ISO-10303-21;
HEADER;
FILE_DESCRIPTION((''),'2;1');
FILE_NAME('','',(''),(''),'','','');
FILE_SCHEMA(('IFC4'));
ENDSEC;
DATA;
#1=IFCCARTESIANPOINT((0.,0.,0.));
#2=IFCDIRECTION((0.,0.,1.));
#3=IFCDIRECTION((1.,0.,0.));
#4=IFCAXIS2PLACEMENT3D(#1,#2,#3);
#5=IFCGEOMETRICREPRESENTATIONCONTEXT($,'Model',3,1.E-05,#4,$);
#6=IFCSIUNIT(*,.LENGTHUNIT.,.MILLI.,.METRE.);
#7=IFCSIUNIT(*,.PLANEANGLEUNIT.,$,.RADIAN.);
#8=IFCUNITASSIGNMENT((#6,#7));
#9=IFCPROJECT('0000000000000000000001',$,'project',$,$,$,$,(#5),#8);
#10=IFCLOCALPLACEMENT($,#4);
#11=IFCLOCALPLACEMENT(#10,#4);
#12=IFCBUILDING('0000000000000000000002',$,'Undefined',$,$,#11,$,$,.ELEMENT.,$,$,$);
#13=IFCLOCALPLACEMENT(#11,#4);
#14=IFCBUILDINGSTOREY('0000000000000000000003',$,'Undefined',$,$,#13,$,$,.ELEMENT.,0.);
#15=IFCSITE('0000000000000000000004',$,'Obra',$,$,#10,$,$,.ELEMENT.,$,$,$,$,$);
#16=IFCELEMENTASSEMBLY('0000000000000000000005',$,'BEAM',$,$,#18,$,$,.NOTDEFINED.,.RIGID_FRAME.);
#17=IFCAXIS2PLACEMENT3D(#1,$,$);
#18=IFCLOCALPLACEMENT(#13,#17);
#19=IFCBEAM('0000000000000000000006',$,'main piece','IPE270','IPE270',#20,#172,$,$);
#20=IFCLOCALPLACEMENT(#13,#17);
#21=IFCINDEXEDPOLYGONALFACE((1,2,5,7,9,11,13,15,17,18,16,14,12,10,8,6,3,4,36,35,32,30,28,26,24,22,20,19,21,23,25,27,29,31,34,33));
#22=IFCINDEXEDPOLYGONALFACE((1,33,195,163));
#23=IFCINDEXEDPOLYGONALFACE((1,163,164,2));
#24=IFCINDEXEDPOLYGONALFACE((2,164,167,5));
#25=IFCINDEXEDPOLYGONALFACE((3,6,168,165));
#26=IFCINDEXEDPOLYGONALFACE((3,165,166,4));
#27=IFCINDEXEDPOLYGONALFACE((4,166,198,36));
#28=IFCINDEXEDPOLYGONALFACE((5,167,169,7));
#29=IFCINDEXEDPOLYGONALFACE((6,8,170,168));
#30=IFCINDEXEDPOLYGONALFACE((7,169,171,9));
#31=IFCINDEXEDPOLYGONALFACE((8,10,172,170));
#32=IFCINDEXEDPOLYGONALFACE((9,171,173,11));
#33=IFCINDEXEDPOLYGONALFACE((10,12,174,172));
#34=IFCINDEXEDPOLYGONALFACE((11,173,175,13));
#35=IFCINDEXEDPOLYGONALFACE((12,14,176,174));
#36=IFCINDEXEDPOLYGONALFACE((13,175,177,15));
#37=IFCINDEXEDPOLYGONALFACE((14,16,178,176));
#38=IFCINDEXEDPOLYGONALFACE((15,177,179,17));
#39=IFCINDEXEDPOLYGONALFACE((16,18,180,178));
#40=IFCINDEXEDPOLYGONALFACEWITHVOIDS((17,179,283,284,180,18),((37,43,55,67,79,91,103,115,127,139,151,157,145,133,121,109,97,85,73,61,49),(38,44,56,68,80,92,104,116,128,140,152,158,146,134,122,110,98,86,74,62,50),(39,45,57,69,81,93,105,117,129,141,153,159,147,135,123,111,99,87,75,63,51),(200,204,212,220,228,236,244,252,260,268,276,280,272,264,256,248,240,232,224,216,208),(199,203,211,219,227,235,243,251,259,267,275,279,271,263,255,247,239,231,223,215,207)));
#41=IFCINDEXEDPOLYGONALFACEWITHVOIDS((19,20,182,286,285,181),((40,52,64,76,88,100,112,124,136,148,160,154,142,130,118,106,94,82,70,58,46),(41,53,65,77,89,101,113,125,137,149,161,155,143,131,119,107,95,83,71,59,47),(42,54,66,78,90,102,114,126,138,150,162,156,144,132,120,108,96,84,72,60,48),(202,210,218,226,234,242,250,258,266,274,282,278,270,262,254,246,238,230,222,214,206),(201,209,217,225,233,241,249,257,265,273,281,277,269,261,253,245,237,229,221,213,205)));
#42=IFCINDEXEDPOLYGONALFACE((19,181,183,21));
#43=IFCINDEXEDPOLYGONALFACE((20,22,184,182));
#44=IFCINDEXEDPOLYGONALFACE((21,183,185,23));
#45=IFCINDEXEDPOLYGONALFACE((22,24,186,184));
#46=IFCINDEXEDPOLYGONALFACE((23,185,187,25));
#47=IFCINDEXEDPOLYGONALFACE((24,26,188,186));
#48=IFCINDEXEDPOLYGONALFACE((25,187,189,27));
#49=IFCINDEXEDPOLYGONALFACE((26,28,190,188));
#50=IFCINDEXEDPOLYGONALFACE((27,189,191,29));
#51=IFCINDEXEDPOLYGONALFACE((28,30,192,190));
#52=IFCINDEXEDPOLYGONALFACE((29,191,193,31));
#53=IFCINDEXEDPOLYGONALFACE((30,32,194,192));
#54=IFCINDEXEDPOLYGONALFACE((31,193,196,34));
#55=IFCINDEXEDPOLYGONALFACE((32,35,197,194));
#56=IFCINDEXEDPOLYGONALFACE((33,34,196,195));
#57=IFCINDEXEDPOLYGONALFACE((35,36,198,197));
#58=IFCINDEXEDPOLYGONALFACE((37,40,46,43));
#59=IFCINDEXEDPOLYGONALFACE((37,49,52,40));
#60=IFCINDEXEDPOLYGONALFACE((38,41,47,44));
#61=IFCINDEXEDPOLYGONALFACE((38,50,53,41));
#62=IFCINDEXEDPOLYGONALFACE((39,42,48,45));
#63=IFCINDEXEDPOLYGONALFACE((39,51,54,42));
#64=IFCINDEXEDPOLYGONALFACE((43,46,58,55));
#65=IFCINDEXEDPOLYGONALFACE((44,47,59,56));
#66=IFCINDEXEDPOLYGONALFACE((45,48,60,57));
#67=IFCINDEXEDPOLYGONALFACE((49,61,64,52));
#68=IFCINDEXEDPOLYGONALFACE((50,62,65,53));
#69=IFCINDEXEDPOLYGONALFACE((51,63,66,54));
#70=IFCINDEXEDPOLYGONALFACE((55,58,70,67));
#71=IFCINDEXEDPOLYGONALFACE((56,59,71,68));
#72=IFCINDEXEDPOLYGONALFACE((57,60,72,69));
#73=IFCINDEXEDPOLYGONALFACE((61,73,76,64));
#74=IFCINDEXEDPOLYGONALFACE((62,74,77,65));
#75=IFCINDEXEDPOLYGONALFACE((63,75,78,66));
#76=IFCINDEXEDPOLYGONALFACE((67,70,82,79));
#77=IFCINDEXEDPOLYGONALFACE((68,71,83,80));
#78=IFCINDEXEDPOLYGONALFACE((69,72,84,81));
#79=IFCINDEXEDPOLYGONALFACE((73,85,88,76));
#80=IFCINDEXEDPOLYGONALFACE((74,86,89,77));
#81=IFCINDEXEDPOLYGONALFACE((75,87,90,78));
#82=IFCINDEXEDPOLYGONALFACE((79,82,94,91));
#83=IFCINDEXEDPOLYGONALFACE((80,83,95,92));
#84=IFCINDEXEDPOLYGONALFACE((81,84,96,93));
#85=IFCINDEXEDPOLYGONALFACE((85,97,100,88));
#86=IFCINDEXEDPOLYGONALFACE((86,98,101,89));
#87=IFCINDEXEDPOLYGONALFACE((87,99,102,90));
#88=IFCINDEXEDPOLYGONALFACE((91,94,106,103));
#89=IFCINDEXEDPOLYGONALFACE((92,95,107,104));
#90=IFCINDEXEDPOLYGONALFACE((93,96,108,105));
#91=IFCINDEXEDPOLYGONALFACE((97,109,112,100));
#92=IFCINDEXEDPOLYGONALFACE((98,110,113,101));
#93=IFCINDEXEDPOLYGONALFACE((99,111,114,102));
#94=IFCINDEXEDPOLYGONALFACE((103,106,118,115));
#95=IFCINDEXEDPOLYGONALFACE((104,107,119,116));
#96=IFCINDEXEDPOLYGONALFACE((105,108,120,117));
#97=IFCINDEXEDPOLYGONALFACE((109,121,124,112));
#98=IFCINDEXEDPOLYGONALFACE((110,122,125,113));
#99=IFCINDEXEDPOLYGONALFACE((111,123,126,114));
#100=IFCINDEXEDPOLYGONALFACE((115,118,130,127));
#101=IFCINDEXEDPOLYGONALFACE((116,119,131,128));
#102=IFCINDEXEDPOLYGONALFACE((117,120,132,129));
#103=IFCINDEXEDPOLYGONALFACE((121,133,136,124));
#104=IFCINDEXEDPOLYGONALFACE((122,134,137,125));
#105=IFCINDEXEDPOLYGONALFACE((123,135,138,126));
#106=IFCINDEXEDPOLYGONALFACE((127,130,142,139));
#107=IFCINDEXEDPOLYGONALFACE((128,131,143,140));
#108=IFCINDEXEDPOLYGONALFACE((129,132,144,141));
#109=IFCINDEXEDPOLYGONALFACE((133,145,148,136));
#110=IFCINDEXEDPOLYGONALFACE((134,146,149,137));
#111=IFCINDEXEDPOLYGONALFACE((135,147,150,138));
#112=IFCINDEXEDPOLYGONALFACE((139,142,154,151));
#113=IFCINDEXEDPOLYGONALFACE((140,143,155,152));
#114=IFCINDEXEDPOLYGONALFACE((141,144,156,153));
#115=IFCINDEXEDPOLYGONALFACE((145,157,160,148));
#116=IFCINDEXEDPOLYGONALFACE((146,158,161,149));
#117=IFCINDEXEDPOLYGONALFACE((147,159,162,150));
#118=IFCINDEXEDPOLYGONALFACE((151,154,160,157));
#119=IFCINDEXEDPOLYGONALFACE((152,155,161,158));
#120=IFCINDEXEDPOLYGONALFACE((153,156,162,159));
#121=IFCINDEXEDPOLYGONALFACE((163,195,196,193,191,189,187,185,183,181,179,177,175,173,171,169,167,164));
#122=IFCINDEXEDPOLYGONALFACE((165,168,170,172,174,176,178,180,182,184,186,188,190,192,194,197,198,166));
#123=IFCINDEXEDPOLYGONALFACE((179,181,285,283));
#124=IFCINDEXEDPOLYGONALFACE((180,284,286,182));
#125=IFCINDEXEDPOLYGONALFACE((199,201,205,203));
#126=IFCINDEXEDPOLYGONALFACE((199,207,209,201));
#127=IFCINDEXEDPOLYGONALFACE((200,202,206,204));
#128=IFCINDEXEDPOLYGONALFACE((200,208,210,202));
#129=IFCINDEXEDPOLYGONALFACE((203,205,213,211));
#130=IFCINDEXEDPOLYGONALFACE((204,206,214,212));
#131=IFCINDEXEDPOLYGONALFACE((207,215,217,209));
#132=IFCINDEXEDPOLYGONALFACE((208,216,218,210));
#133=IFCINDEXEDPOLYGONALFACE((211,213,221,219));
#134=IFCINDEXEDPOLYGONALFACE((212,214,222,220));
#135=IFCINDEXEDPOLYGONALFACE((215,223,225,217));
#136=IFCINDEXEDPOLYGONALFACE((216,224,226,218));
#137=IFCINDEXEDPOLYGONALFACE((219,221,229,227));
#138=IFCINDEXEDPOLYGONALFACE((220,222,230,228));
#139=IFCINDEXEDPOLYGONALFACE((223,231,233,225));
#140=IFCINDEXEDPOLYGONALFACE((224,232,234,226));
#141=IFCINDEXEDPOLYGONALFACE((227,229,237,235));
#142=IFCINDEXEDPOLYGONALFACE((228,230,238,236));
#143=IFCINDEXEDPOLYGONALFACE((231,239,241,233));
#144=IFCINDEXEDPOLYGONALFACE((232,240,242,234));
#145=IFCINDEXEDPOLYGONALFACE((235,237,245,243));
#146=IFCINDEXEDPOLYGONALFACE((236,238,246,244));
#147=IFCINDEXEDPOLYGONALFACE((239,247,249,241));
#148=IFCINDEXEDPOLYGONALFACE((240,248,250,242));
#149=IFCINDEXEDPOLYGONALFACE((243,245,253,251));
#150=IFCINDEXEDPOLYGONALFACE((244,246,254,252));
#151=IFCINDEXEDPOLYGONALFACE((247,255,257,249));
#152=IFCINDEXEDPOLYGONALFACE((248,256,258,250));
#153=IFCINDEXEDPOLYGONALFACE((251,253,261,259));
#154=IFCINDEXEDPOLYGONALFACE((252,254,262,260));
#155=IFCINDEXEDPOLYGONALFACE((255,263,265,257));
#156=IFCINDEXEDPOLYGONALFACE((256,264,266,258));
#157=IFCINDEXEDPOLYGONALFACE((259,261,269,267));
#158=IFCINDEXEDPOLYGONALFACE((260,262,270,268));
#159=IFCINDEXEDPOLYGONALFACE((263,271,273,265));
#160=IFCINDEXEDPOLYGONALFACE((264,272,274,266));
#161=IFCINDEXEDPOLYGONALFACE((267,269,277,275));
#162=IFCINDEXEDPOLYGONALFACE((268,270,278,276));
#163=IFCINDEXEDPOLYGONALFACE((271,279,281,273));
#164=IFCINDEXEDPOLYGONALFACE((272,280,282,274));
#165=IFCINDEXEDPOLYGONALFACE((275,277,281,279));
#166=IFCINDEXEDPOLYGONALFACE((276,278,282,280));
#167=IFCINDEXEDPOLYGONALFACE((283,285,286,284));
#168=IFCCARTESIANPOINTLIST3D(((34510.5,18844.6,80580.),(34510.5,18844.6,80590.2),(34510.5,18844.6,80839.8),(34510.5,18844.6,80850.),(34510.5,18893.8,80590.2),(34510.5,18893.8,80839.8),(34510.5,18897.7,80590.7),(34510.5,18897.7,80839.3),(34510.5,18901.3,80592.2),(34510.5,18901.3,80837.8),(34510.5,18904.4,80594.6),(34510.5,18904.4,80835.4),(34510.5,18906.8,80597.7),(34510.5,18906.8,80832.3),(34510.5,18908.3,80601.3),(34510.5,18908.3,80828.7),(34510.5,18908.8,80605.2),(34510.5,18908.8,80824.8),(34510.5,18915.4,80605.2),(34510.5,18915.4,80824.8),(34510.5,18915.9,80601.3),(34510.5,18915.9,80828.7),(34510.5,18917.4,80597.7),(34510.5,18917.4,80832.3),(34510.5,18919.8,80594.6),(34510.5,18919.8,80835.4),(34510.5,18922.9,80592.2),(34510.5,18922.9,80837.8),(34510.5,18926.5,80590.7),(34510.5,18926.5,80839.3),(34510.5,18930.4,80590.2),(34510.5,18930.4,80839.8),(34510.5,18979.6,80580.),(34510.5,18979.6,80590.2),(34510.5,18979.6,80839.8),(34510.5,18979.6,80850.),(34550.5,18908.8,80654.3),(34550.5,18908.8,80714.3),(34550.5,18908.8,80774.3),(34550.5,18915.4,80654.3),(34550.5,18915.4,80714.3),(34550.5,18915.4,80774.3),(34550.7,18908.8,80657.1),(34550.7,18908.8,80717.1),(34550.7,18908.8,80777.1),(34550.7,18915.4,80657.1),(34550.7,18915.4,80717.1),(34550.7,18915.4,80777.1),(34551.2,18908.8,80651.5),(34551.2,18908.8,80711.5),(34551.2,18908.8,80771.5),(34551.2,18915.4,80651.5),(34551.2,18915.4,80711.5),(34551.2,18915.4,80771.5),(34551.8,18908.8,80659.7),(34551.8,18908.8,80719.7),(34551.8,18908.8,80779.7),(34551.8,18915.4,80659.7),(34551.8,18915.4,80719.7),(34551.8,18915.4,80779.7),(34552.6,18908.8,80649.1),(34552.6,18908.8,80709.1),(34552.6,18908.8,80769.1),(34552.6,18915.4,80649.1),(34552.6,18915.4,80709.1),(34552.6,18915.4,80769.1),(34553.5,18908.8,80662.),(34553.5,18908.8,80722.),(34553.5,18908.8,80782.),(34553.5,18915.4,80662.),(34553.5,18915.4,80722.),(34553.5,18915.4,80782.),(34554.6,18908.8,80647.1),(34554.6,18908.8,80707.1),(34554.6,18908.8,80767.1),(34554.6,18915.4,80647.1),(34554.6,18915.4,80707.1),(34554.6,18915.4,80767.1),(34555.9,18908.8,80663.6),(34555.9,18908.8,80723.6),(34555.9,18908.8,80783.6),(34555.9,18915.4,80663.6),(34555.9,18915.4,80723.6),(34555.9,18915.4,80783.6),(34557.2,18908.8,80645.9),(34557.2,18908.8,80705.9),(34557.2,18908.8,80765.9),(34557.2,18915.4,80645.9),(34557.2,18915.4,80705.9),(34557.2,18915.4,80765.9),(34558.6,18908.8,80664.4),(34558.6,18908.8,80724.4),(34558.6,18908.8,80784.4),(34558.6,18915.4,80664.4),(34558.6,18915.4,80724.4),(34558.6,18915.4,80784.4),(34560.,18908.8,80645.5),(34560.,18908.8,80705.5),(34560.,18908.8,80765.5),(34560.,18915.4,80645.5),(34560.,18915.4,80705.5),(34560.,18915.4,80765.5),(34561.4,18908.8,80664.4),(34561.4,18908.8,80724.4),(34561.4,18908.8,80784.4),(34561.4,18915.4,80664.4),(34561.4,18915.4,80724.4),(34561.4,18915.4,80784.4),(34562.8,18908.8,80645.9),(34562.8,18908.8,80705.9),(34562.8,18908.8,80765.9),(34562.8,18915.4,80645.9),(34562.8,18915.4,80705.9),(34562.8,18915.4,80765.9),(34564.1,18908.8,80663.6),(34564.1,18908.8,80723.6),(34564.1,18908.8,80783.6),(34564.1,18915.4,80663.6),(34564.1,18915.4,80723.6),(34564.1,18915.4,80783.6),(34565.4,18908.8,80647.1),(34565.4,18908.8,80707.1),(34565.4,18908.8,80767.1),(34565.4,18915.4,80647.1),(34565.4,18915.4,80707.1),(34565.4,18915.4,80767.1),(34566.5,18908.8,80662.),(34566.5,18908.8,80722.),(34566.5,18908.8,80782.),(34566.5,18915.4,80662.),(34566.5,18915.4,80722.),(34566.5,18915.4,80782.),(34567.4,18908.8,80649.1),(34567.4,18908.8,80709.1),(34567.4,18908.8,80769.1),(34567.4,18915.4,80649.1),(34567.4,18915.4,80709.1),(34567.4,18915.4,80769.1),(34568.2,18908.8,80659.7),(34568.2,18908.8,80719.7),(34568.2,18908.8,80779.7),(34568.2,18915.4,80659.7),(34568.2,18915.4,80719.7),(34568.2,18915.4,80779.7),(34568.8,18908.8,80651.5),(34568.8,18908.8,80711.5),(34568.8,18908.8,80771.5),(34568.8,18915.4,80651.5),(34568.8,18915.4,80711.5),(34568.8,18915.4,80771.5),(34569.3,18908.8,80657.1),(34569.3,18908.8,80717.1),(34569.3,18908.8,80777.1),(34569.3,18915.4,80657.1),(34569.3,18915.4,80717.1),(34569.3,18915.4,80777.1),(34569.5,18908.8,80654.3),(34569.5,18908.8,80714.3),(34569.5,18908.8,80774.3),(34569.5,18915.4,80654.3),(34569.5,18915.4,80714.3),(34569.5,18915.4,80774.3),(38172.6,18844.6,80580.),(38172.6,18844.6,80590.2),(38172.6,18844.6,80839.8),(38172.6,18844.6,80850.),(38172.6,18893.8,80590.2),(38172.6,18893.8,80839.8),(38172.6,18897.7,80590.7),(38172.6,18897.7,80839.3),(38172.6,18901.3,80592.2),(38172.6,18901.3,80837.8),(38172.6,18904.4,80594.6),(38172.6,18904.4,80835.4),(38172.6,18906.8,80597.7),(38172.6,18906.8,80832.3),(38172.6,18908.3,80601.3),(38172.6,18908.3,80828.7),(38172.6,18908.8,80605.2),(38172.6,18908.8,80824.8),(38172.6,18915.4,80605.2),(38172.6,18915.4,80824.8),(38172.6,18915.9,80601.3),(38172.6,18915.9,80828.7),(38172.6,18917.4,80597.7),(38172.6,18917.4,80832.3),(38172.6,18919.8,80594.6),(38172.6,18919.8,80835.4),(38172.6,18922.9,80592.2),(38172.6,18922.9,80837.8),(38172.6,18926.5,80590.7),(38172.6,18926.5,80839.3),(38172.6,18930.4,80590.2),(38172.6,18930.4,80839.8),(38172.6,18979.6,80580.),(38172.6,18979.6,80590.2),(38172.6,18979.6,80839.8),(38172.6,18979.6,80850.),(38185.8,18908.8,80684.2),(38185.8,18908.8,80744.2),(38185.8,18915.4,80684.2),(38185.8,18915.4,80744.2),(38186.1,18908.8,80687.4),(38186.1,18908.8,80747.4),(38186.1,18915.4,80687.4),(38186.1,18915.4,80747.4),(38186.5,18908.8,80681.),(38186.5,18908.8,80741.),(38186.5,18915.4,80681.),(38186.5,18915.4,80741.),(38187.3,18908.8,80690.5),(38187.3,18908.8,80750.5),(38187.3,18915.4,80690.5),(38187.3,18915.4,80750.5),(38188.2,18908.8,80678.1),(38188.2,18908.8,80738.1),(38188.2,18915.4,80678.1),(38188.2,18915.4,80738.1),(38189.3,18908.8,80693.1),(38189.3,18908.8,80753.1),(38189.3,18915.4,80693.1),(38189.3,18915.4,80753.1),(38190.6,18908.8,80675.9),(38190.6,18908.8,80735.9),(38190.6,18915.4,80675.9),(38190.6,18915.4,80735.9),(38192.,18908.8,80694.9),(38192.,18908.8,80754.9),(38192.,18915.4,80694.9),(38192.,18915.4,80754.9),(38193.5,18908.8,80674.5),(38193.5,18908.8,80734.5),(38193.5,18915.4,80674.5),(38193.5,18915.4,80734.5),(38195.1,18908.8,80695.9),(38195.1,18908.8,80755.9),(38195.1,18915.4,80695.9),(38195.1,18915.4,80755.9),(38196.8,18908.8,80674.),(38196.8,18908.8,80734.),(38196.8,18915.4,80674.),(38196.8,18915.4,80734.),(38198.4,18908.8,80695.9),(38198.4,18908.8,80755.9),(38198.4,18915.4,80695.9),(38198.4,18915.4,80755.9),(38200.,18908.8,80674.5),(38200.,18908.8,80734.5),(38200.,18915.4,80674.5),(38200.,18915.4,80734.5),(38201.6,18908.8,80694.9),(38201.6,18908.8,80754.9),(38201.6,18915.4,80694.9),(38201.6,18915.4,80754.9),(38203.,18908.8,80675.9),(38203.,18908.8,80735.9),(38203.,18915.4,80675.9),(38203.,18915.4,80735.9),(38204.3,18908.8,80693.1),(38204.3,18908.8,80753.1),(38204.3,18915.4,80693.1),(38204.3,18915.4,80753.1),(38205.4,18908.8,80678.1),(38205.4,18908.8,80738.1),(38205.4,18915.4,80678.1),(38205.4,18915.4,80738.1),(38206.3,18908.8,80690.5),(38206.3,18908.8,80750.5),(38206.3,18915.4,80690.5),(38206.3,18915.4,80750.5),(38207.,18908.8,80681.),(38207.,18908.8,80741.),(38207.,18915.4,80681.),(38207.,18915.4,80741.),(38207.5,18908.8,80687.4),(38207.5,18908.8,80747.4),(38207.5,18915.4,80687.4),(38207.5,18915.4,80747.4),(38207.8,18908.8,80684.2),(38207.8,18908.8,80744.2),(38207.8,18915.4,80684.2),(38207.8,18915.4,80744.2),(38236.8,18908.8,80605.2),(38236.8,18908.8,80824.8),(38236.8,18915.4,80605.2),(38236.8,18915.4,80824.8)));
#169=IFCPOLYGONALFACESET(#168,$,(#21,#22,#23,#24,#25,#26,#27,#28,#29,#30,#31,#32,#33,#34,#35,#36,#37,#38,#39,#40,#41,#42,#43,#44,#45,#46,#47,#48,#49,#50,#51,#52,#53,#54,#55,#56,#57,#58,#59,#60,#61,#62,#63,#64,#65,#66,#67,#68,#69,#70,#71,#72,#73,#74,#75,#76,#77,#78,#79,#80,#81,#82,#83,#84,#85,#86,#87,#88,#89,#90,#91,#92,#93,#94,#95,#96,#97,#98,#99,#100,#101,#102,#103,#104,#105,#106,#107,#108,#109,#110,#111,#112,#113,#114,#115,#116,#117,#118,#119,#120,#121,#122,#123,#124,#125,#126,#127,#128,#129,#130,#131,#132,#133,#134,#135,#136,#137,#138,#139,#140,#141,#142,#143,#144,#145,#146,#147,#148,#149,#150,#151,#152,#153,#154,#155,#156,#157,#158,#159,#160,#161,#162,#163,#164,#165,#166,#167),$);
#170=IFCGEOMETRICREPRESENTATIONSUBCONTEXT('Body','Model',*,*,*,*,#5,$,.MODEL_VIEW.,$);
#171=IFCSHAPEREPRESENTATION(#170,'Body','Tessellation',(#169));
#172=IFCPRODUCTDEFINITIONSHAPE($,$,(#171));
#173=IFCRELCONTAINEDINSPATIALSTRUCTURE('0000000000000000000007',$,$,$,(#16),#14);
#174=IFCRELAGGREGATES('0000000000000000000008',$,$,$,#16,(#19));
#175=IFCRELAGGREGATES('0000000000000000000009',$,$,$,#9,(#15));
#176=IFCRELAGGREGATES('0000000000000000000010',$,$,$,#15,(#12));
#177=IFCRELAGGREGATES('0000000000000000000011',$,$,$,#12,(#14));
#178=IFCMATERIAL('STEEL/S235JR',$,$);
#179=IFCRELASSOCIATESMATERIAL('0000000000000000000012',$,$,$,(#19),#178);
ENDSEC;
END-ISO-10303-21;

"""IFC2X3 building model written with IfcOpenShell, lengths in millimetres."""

from ifc_helpers import new_model, si_unit, frame, origin_with_axes, origin_2d_with_axis, place, context, subcontext, project, spatial, rectangle, circle, i_section, extrude, clip, halfspace, source, transform, mapped, material, element, aggregate, save


model = new_model("IFC2X3")

# Units and contexts
model_context = context("Model", 3, precision=1e-05, world=origin_with_axes())
body_context = subcontext(model_context, "Body", "Model", "MODEL_VIEW")
ifc_project = project(units=[si_unit("LENGTHUNIT", "METRE", prefix="MILLI"), si_unit("PLANEANGLEUNIT", "RADIAN")], contexts=[model_context])

# Site, building, storey
site_placement = place(None, origin_with_axes())
site = spatial("IfcSite", under=ifc_project, at=site_placement, Name="Obra", CompositionType="ELEMENT")
building_placement = place(site_placement, origin_with_axes())
building = spatial("IfcBuilding", under=site, at=building_placement, Name="Undefined", CompositionType="ELEMENT")
storey_placement = place(building_placement, origin_with_axes())
storey = spatial("IfcBuildingStorey", under=building, at=storey_placement, Name="Undefined", CompositionType="ELEMENT", Elevation=0.0)

# Element assembly, beam, openings
ifc_material_1 = material(Name="STEEL/S235JR")
shared_shape_1 = source(origin_with_axes(), body_context, "Body", "SweptSolid", [
    extrude(circle(Radius=9.5, at=origin_2d_with_axis()), frame((0.0, -3.4, 0.0), z_axis=(0.0, 1.0, 0.0), x_axis=(1.0, 0.0, 0.0)), (0.0, 0.0, 1.0), 6.8),
])
assembly_1_placement = place(storey_placement, origin_with_axes())
assembly_1 = element("IfcElementAssembly", 1, at=assembly_1_placement, inside=storey, Name="BEAM", AssemblyPlace="NOTDEFINED", PredefinedType="RIGID_FRAME")
beam_1_placement = place(assembly_1_placement, frame((34251.7, 18912.1, 80715.0), z_axis=(0.0, 0.0, 1.0), x_axis=(1.0, 0.0, 0.0)))
beam_1 = element("IfcBeam", 2, at=beam_1_placement, material=ifc_material_1, Name="main piece", Description="IPE270", ObjectType="IPE270", context=body_context, shape_type="Clipping", body=[
    clip(clip(extrude(i_section(OverallWidth=135.0, OverallDepth=270.0, WebThickness=6.6, FlangeThickness=10.2, FilletRadius=15.0, at=origin_2d_with_axis()), frame((3985.1, 0.0, 0.0), z_axis=(-1.0, 0.0, 0.0), x_axis=(0.0, -1.0, 0.0)), (0.0, 0.0, 1.0), 3985.1), halfspace(frame((258.8, 60.0, -120.0), z_axis=(-1.0, -0.000019, 0.0), x_axis=(0.0, 0.0, 1.0)), False)), halfspace(frame((3985.1, 0.0, -235.0), z_axis=(-1.0, 0.0, 0.0), x_axis=(0.0, 1.0, 0.0)), True)),
])
opening_1_placement = place(assembly_1_placement, frame((34251.7, 18912.1, 80715.0), z_axis=(0.0, 0.0, 1.0), x_axis=(1.0, 0.0, 0.0)))
element("IfcOpeningElement", 3, at=opening_1_placement, cuts=beam_1, ObjectType="Recess", context=body_context, shape_type="SweptSolid", body=[
    extrude(rectangle(XDim=26.2, YDim=76.2, at=origin_2d_with_axis()), frame((3959.0, 68.5, -122.9), z_axis=(0.0, -1.0, 0.0), x_axis=(0.0, 0.0, -1.0)), (0.0, 0.0, 1.0), 137.0),
])
opening_2_placement = place(assembly_1_placement, frame((34251.7, 18912.1, 80715.0), z_axis=(0.0, 0.0, 1.0), x_axis=(1.0, 0.0, 0.0)))
element("IfcOpeningElement", 4, at=opening_2_placement, cuts=beam_1, ObjectType="Recess", context=body_context, shape_type="SweptSolid", body=[
    extrude(rectangle(XDim=26.2, YDim=76.2, at=origin_2d_with_axis()), frame((3959.0, 68.5, 122.9), z_axis=(0.0, -1.0, 0.0), x_axis=(0.0, 0.0, -1.0)), (0.0, 0.0, 1.0), 137.0),
])
shared_shape_2 = source(origin_with_axes(), body_context, "Body", "SweptSolid", [
    extrude(circle(Radius=11.0, at=origin_2d_with_axis()), frame((0.0, -3.4, 0.0), z_axis=(0.0, 1.0, 0.0), x_axis=(1.0, 0.0, 0.0)), (0.0, 0.0, 1.0), 6.8),
])
opening_3_placement = place(assembly_1_placement, frame((38236.8, 18912.1, 80850.0), z_axis=(-1.0, 0.0, 0.0), x_axis=(0.0, 0.0, -1.0)))
element("IfcOpeningElement", 5, at=opening_3_placement, cuts=beam_1, ObjectType="Opening", context=body_context, shape_type="MappedRepresentation", body=[
    mapped(shared_shape_2, transform((105.0, 0.0, 40.0))),
    mapped(shared_shape_2, transform((165.0, 0.0, 40.0))),
])
opening_4_placement = place(assembly_1_placement, frame((34510.0, 18912.1, 80835.0), z_axis=(1.0, 0.0, 0.0), x_axis=(0.0, 0.0, -1.0)))
element("IfcOpeningElement", 6, at=opening_4_placement, cuts=beam_1, ObjectType="Opening", context=body_context, shape_type="MappedRepresentation", body=[
    mapped(shared_shape_1, transform((60.0, 0.0, 50.0))),
    mapped(shared_shape_1, transform((120.0, 0.0, 50.0))),
    mapped(shared_shape_1, transform((180.0, 0.0, 50.0))),
])

aggregate(assembly_1, [beam_1])

save(model, "model.ifc")
